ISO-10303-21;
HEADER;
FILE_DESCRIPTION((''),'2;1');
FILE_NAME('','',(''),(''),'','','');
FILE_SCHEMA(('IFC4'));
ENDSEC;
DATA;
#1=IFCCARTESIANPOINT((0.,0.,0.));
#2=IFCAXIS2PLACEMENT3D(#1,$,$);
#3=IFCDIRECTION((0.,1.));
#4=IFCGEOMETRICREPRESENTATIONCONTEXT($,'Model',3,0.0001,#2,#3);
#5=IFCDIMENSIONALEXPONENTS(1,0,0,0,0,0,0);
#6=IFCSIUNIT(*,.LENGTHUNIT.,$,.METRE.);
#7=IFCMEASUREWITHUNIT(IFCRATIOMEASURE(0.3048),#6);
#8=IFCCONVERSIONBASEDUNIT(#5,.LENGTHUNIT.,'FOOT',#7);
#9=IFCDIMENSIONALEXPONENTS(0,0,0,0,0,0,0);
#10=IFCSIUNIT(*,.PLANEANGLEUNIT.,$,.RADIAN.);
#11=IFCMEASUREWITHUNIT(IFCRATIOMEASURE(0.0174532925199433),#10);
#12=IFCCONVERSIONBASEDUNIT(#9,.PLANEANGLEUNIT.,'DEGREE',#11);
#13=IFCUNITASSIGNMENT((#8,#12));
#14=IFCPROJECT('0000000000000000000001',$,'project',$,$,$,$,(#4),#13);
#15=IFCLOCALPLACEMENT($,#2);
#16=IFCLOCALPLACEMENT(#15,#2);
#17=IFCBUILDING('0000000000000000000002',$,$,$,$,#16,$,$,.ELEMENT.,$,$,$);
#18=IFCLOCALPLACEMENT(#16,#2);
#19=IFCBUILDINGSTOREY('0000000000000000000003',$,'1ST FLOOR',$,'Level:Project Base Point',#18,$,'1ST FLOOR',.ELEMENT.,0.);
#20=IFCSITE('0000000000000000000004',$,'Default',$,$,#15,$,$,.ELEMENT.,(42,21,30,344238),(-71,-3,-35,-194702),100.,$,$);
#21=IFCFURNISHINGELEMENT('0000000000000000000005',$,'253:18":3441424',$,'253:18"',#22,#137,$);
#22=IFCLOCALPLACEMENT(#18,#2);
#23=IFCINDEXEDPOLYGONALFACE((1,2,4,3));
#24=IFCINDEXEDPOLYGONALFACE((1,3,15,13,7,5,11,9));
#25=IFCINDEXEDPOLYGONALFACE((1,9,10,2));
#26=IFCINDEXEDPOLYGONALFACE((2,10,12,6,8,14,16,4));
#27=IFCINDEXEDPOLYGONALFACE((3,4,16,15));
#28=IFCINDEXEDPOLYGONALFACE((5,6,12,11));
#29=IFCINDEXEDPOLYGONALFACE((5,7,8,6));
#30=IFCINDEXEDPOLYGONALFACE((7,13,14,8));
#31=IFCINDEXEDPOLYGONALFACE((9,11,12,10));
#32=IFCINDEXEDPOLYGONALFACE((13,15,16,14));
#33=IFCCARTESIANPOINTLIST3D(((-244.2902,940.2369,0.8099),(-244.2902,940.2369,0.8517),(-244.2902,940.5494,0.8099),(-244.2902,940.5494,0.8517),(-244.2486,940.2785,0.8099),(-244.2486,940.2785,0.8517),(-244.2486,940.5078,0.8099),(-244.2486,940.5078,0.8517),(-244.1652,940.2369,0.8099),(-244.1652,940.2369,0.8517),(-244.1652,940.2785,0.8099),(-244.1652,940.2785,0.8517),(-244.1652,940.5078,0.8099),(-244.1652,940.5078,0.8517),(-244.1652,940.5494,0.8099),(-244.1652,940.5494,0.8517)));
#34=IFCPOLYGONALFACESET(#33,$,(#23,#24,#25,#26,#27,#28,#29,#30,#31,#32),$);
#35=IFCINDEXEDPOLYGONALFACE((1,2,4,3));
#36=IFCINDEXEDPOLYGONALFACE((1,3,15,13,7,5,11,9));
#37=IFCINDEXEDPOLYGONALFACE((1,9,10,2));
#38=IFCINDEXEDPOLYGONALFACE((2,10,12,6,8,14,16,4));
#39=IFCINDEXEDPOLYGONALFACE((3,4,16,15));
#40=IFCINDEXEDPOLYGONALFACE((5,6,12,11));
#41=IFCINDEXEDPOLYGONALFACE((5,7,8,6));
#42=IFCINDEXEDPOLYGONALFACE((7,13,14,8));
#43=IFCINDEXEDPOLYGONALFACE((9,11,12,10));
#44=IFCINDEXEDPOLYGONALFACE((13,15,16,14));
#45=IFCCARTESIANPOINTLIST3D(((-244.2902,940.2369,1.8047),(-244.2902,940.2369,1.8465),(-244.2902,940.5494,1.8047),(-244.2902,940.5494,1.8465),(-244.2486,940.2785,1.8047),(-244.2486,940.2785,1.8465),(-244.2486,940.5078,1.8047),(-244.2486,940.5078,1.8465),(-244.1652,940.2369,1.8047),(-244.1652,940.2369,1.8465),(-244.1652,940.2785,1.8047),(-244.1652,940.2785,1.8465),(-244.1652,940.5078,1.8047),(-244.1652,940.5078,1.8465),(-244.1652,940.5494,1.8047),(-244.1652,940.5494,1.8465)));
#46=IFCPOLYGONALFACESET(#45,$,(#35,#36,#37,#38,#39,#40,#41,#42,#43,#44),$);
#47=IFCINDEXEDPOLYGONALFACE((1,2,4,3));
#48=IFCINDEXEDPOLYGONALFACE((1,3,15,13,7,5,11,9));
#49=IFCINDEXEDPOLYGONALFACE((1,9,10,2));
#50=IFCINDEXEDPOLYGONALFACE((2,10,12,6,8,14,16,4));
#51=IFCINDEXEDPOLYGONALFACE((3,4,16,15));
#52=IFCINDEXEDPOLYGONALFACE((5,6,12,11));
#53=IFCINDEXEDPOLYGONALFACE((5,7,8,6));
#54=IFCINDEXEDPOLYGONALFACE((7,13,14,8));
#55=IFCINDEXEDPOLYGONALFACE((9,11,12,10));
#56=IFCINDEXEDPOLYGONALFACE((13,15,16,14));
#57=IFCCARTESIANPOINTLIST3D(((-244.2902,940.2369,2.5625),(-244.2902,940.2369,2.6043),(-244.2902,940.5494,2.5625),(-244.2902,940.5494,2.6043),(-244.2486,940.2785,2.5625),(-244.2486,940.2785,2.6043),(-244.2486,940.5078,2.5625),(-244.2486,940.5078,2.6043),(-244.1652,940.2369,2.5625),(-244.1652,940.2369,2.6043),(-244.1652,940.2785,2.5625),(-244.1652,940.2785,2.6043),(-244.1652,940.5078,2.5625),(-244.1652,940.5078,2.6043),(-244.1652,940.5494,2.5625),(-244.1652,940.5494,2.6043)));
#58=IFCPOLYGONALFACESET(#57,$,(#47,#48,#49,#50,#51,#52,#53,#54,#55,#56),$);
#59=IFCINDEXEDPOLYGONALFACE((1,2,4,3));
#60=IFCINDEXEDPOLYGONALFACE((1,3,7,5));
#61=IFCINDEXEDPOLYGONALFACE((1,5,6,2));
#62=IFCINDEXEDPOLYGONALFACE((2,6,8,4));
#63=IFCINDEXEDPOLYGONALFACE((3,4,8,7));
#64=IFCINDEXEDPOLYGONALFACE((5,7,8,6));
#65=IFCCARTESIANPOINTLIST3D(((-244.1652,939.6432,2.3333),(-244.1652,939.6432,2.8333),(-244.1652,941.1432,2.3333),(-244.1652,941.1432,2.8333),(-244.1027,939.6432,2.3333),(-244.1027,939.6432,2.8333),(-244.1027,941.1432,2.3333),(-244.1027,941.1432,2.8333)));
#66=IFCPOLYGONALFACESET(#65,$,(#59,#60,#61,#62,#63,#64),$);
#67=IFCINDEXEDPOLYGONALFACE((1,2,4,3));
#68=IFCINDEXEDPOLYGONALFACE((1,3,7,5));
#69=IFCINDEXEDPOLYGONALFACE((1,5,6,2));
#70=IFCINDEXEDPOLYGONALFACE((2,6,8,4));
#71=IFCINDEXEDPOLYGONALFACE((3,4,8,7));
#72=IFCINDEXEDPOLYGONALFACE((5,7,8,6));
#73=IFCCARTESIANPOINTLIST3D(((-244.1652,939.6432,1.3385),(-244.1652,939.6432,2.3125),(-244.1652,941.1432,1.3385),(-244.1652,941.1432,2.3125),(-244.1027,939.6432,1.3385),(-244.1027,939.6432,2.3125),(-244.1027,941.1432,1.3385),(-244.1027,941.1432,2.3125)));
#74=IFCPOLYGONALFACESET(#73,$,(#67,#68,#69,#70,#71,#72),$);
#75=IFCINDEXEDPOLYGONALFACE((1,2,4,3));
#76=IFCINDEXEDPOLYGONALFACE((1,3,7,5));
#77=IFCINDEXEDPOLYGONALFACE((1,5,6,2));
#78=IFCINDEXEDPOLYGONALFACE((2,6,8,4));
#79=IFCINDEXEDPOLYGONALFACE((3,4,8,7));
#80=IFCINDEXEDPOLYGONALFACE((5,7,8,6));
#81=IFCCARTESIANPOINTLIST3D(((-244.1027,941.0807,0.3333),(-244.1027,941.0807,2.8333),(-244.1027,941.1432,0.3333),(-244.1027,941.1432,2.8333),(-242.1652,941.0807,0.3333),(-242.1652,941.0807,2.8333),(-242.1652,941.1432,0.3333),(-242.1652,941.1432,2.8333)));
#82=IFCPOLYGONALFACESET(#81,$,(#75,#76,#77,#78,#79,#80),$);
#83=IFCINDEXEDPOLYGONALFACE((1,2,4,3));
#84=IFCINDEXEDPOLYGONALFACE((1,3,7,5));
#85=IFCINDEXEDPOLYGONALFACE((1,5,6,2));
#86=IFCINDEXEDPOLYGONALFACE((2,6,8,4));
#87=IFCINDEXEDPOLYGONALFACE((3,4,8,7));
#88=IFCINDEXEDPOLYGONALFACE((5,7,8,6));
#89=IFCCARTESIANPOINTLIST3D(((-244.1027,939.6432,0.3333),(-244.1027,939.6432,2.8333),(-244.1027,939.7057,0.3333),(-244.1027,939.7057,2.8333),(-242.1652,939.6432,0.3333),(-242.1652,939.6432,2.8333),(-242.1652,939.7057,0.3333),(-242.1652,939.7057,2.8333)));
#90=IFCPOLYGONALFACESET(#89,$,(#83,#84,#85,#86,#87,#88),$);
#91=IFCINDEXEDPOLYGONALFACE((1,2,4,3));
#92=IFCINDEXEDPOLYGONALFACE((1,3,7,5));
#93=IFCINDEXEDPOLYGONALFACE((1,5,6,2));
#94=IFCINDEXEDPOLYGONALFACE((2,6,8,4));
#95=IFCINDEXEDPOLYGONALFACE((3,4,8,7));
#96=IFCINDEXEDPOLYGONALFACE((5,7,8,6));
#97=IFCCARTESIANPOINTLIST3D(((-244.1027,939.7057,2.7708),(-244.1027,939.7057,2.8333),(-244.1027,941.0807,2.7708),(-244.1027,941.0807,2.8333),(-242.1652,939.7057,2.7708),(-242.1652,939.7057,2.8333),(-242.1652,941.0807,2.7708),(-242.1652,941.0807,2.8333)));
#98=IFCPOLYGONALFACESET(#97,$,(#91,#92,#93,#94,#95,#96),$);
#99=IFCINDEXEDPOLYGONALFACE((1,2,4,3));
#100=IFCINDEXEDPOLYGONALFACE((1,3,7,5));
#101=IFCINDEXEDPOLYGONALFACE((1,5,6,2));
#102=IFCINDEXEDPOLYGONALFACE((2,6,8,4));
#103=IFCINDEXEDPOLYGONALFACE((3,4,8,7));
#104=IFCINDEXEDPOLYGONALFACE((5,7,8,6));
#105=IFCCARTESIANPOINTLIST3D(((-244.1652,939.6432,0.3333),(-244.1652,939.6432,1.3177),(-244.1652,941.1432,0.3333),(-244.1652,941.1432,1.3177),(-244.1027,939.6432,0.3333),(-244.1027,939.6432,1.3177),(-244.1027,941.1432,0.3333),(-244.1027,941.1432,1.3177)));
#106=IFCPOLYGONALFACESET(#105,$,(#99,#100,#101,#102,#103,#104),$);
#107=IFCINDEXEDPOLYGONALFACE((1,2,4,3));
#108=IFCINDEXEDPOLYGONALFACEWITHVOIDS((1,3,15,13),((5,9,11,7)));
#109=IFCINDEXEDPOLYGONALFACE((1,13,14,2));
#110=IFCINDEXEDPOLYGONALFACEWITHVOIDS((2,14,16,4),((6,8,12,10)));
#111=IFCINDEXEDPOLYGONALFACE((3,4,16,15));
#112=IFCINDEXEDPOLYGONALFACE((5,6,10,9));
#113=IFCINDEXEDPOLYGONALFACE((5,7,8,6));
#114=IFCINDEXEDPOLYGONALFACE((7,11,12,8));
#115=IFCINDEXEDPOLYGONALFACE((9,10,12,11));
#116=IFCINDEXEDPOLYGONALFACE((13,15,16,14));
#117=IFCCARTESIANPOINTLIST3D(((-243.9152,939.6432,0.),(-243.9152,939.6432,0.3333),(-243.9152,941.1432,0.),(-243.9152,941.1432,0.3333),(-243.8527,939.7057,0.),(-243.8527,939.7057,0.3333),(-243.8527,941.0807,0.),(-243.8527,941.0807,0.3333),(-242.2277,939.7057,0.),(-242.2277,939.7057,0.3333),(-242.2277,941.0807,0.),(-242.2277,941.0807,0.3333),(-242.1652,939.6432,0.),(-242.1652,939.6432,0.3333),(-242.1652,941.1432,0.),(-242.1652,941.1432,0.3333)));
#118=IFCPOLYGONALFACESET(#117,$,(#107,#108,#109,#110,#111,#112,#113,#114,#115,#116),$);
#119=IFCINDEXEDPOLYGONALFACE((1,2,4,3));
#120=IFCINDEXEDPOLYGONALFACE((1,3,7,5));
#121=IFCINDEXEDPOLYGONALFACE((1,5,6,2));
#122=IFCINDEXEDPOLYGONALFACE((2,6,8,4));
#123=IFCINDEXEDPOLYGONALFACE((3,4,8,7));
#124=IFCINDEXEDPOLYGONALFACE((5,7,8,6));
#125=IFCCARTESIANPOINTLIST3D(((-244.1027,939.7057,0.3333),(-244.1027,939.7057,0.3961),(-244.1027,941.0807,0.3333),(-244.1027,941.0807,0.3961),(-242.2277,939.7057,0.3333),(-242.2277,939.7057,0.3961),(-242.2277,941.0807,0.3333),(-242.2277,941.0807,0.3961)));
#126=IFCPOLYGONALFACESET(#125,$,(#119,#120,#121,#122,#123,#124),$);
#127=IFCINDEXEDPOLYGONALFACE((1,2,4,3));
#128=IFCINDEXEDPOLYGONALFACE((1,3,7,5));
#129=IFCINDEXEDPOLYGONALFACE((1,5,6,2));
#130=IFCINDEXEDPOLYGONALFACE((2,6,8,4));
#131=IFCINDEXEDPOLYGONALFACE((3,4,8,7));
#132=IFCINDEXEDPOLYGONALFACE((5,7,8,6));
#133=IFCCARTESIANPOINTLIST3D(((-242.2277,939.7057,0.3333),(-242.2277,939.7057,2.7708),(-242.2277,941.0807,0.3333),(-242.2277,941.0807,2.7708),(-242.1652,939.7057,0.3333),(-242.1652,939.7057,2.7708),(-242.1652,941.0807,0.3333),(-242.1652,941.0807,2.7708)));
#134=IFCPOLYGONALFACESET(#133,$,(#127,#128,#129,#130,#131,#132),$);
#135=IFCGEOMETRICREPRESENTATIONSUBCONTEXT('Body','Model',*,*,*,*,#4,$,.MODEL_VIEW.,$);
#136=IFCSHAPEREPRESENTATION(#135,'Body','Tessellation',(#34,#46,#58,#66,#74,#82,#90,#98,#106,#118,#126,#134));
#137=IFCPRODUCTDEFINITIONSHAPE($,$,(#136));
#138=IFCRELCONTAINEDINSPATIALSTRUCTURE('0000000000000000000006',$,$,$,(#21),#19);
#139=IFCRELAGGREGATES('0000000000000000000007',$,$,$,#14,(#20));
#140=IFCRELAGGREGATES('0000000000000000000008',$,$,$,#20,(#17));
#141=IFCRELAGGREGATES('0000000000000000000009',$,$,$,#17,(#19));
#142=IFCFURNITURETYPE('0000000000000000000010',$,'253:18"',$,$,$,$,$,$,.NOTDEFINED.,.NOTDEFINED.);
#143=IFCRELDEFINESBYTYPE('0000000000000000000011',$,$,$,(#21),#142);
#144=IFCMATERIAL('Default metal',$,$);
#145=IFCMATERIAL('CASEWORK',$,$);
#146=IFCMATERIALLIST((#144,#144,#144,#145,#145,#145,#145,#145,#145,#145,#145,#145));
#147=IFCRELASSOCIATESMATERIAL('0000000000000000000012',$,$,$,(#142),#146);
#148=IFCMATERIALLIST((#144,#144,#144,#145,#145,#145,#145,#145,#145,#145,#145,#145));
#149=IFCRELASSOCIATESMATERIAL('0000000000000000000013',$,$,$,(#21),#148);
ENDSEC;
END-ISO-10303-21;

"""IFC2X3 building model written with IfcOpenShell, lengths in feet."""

from ifc_helpers import new_model, entity, si_unit, converted_unit, direction, frame, frame_2d, origin, origin_2d_with_axis, place, context, subcontext, project, spatial, polyline, rectangle, outline, extrude, source, transform, mapped, material, material_list, type_object, type_shapes, element, save


model = new_model("IFC2X3")

# Units and contexts
model_context = context("Model", 3, precision=0.0001, world=origin(), true_north=direction((0.0, 1.0)))
body_context = subcontext(model_context, "Body", "Model", "MODEL_VIEW")
ifc_project = project(units=[converted_unit("LENGTHUNIT", "FOOT", entity("IfcRatioMeasure", 0.3048), si_unit("LENGTHUNIT", "METRE"), dimensions=[1, 0, 0, 0, 0, 0, 0]), converted_unit("PLANEANGLEUNIT", "DEGREE", entity("IfcRatioMeasure", 0.0174532925199433), si_unit("PLANEANGLEUNIT", "RADIAN"), dimensions=[0, 0, 0, 0, 0, 0, 0])], contexts=[model_context])

# Site, building, storey
site_placement = place(None, origin())
site = spatial("IfcSite", under=ifc_project, at=site_placement, Name="Default", CompositionType="ELEMENT", RefLatitude=(42, 21, 30, 344238), RefLongitude=(-71, -3, -35, -194702), RefElevation=100.0)
building_placement = place(site_placement, origin())
building = spatial("IfcBuilding", under=site, at=building_placement, CompositionType="ELEMENT")
storey_placement = place(building_placement, origin())
storey = spatial("IfcBuildingStorey", under=building, at=storey_placement, Name="1ST FLOOR", ObjectType="Level:Project Base Point", LongName="1ST FLOOR", CompositionType="ELEMENT", Elevation=0.0)

# Furnishing element
ifc_material_1 = material(Name="Default metal")
ifc_material_2 = material(Name="CASEWORK")
ifc_material_list_1 = material_list([ifc_material_1, ifc_material_1, ifc_material_1, ifc_material_2, ifc_material_2, ifc_material_2, ifc_material_2, ifc_material_2, ifc_material_2, ifc_material_2, ifc_material_2, ifc_material_2])
ifc_material_list_2 = material_list([ifc_material_1, ifc_material_1, ifc_material_1, ifc_material_2, ifc_material_2, ifc_material_2, ifc_material_2, ifc_material_2, ifc_material_2, ifc_material_2, ifc_material_2, ifc_material_2])
furniture_type_1 = type_object("IfcFurnitureType", Name="253:18\"", material=ifc_material_list_2)
shared_shape_1 = source(origin(), body_context, "Body", "SweptSolid", [
    extrude(outline(polyline([(-0.0521, -0.1562), (0.0729, -0.1562), (0.0729, 0.1562), (-0.0521, 0.1562), (-0.0521, 0.1146), (0.0313, 0.1146), (0.0313, -0.1146), (-0.0521, -0.1146), (-0.0521, -0.1562)])), frame((0.0615, -2.0521, 0.8099), z_axis=(0.0, 0.0, 1.0), x_axis=(0.0, -1.0, 0.0)), (0.0, 0.0, 1.0), 0.0418),
    extrude(outline(polyline([(-0.0521, -0.1562), (0.0729, -0.1562), (0.0729, 0.1562), (-0.0521, 0.1562), (-0.0521, 0.1146), (0.0313, 0.1146), (0.0313, -0.1146), (-0.0521, -0.1146), (-0.0521, -0.1562)])), frame((0.0615, -2.0521, 1.8047), z_axis=(0.0, 0.0, 1.0), x_axis=(0.0, -1.0, 0.0)), (0.0, 0.0, 1.0), 0.0418),
    extrude(outline(polyline([(-0.0521, -0.1562), (0.0729, -0.1562), (0.0729, 0.1562), (-0.0521, 0.1562), (-0.0521, 0.1146), (0.0313, 0.1146), (0.0313, -0.1146), (-0.0521, -0.1146), (-0.0521, -0.1562)])), frame((0.0615, -2.0521, 2.5625), z_axis=(0.0, 0.0, 1.0), x_axis=(0.0, -1.0, 0.0)), (0.0, 0.0, 1.0), 0.0418),
    extrude(rectangle(XDim=0.0625, YDim=1.5, at=frame_2d((0.0, 0.0), x_axis=(1.0, 0.0))), frame((0.0615, -1.9688, 2.3333), z_axis=(0.0, 0.0, 1.0), x_axis=(0.0, 1.0, 0.0)), (0.0, 0.0, 1.0), 0.5),
    extrude(rectangle(XDim=0.0625, YDim=1.5, at=frame_2d((0.0, 0.0), x_axis=(1.0, 0.0))), frame((0.0615, -1.9688, 1.3385), z_axis=(0.0, 0.0, 1.0), x_axis=(0.0, 1.0, 0.0)), (0.0, 0.0, 1.0), 0.974),
    extrude(rectangle(XDim=0.0625, YDim=1.9375, at=frame_2d((0.0, 0.0), x_axis=(1.0, 0.0))), frame((-0.6573, -0.9687, 0.3333)), (0.0, 0.0, 1.0), 2.5),
    extrude(rectangle(XDim=0.0625, YDim=1.9375, at=frame_2d((0.0, 0.0), x_axis=(1.0, 0.0))), frame((0.7802, -0.9687, 0.3333)), (0.0, 0.0, 1.0), 2.5),
    extrude(rectangle(XDim=1.375, YDim=1.9375, at=origin_2d_with_axis()), frame((0.0615, -0.9688, 2.7708), z_axis=(0.0, 0.0, 1.0), x_axis=(-1.0, 0.0, 0.0)), (0.0, 0.0, 1.0), 0.0625),
    extrude(rectangle(XDim=0.0625, YDim=1.5, at=frame_2d((0.0, 0.0), x_axis=(1.0, 0.0))), frame((0.0615, -1.9688, 0.3333), z_axis=(0.0, 0.0, 1.0), x_axis=(0.0, 1.0, 0.0)), (0.0, 0.0, 1.0), 0.9844),
    extrude(outline(polyline([(-0.75, -0.875), (0.75, -0.875), (0.75, 0.875), (-0.75, 0.875), (-0.75, -0.875)]), holes=[polyline([(-0.6875, -0.8125), (-0.6875, 0.8125), (0.6875, 0.8125), (0.6875, -0.8125), (-0.6875, -0.8125)])]), frame((0.0615, -0.875, 0.0)), (0.0, 0.0, 1.0), 0.3333),
    extrude(rectangle(XDim=1.375, YDim=1.875, at=frame_2d((0.0, 0.0), x_axis=(1.0, 0.0))), frame((0.0615, -1.0, 0.3333), z_axis=(0.0, 0.0, 1.0), x_axis=(-1.0, 0.0, 0.0)), (0.0, 0.0, 1.0), 0.0627),
    extrude(rectangle(XDim=0.0625, YDim=1.375, at=origin_2d_with_axis()), frame((0.0615, -0.0312, 0.3333), z_axis=(0.0, 0.0, 1.0), x_axis=(0.0, 1.0, 0.0)), (0.0, 0.0, 1.0), 2.4375),
])
type_shapes(furniture_type_1, [shared_shape_1])
furnishing_1_placement = place(storey_placement, frame((-242.1652, 940.4547, 0.0), z_axis=(0.0, 0.0, 1.0), x_axis=(0.0, -1.0, 0.0)))
element("IfcFurnishingElement", 1, at=furnishing_1_placement, inside=storey, type_object=furniture_type_1, material=ifc_material_list_1, Name="253:18\":3441424", ObjectType="253:18\"", context=body_context, shape_type="MappedRepresentation", body=[
    mapped(shared_shape_1, transform((0.0, 0.0, 0.0), scale=1.0)),
])

save(model, "model.ifc")
